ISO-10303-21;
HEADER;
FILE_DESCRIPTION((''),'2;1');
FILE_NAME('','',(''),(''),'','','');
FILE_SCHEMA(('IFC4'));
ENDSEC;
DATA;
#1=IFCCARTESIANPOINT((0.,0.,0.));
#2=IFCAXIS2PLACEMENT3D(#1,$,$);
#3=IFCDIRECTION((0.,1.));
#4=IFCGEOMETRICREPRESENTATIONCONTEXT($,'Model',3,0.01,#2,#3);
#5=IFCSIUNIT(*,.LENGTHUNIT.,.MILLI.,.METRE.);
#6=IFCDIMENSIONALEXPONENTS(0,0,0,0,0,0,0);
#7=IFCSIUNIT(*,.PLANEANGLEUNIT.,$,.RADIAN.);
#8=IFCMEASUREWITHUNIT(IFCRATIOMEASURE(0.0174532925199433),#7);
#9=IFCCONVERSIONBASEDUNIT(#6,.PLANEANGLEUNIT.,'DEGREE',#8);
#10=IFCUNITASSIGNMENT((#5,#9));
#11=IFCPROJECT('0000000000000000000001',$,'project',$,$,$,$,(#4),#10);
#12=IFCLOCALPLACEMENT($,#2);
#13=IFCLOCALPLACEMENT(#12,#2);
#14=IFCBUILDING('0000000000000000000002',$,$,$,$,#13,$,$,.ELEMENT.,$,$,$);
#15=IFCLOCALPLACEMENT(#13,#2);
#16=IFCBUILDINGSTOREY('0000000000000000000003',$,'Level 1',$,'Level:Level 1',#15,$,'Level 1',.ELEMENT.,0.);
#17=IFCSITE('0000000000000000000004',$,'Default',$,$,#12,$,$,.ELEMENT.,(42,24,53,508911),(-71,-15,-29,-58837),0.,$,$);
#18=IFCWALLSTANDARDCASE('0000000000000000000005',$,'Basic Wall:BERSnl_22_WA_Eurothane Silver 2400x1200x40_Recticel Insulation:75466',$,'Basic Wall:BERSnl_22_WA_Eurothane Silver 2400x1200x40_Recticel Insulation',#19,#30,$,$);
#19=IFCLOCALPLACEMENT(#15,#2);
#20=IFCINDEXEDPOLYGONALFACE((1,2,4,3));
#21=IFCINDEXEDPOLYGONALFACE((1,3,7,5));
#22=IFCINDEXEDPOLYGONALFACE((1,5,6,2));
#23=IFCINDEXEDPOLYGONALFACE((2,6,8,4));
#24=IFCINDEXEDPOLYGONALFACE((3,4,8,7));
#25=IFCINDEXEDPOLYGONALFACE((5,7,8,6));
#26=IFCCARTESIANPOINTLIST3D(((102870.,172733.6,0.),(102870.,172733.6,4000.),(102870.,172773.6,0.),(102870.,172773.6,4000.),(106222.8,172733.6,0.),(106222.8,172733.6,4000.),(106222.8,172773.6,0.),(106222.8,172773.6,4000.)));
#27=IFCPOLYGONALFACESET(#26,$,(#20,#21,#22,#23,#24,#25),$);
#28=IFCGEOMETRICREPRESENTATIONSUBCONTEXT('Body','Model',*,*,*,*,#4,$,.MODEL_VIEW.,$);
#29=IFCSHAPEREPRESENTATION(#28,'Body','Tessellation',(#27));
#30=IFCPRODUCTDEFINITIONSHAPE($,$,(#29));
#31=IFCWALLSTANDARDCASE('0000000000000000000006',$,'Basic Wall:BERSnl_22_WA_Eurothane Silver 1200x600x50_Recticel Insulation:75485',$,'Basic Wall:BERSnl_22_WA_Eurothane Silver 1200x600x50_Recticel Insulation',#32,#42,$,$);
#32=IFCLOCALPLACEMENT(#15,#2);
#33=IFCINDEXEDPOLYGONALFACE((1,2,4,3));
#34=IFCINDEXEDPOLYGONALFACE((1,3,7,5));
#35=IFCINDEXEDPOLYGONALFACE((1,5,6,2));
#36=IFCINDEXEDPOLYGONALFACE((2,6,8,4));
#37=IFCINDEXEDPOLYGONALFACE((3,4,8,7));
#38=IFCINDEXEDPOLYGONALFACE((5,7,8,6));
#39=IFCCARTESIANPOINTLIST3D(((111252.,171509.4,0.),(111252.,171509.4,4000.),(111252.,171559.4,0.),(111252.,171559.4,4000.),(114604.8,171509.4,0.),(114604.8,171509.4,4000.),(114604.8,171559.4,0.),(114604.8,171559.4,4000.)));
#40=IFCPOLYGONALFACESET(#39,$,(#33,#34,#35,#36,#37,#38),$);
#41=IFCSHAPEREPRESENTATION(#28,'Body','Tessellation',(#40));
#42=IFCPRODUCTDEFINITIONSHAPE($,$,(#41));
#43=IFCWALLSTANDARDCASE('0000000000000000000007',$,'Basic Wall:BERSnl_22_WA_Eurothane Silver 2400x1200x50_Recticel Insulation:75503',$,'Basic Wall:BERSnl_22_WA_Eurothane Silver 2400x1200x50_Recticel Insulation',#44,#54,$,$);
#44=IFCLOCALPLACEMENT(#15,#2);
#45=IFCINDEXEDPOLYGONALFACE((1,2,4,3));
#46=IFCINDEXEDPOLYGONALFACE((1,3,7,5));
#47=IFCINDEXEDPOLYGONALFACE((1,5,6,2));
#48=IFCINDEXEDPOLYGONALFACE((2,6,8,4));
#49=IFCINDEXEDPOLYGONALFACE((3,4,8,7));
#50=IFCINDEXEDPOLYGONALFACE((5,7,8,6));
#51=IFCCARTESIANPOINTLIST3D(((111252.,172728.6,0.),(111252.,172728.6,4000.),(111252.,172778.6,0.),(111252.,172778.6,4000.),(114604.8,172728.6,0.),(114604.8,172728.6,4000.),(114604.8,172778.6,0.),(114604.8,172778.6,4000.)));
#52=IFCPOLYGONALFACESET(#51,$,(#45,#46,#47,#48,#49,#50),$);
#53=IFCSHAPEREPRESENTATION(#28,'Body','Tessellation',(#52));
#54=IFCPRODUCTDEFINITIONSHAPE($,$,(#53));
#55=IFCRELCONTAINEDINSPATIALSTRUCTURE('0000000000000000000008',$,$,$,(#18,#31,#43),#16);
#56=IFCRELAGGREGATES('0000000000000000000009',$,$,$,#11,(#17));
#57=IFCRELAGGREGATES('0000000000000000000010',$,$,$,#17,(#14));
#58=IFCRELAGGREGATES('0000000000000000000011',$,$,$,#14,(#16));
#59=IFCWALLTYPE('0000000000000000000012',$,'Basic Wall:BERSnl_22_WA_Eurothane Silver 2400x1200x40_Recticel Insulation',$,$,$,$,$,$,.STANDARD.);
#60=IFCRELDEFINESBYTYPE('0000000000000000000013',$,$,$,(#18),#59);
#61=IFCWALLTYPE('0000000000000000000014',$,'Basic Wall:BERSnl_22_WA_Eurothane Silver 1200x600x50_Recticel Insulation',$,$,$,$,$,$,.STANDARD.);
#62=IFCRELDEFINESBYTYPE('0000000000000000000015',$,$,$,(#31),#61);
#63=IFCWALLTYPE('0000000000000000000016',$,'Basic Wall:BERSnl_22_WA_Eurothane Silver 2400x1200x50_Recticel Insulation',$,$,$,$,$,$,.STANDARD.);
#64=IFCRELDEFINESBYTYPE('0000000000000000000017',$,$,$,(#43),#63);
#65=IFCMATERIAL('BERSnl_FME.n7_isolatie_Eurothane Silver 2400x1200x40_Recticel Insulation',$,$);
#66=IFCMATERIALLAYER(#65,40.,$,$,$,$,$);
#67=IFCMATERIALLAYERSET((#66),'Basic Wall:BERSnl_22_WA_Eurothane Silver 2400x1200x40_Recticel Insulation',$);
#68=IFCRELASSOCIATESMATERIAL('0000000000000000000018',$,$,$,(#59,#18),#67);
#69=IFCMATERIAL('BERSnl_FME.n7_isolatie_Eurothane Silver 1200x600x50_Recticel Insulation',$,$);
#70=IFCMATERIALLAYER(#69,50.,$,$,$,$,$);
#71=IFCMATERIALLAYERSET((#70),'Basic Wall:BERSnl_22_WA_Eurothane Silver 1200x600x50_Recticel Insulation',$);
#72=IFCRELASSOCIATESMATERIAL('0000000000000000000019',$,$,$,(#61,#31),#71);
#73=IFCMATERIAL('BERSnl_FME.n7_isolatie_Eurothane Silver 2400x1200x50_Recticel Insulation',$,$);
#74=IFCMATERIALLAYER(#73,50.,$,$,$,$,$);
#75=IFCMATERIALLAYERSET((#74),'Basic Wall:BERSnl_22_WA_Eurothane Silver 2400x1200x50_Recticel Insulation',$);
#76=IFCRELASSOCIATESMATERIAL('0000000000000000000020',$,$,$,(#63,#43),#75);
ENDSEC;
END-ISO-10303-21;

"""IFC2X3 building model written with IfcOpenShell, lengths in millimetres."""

from ifc_helpers import new_model, entity, si_unit, converted_unit, direction, frame, frame_2d, origin, place, context, subcontext, project, spatial, rectangle, extrude, material, layer, layer_set, layer_usage, type_object, element, save


model = new_model("IFC2X3")

# Units and contexts
model_context = context("Model", 3, precision=0.01, world=origin(), true_north=direction((0.0, 1.0)))
body_context = subcontext(model_context, "Body", "Model", "MODEL_VIEW")
ifc_project = project(units=[si_unit("LENGTHUNIT", "METRE", prefix="MILLI"), converted_unit("PLANEANGLEUNIT", "DEGREE", entity("IfcRatioMeasure", 0.0174532925199433), si_unit("PLANEANGLEUNIT", "RADIAN"), dimensions=[0, 0, 0, 0, 0, 0, 0])], contexts=[model_context])

# Site, building, storey
site_placement = place(None, origin())
site = spatial("IfcSite", under=ifc_project, at=site_placement, Name="Default", CompositionType="ELEMENT", RefLatitude=(42, 24, 53, 508911), RefLongitude=(-71, -15, -29, -58837), RefElevation=0.0)
building_placement = place(site_placement, origin())
building = spatial("IfcBuilding", under=site, at=building_placement, CompositionType="ELEMENT")
storey_placement = place(building_placement, origin())
storey = spatial("IfcBuildingStorey", under=building, at=storey_placement, Name="Level 1", ObjectType="Level:Level 1", LongName="Level 1", CompositionType="ELEMENT", Elevation=0.0)

# Shared definitions
ifc_material_1 = material(Name="BERSnl_FME.n7_isolatie_Eurothane Silver 2400x1200x40_Recticel Insulation")
ifc_material_2 = material(Name="BERSnl_FME.n7_isolatie_Eurothane Silver 1200x600x50_Recticel Insulation")
ifc_material_3 = material(Name="BERSnl_FME.n7_isolatie_Eurothane Silver 2400x1200x50_Recticel Insulation")

# Walls
ifc_layer_1 = layer(ifc_material_1, 40.0)
ifc_layer_set_1 = layer_set([ifc_layer_1], Name="Basic Wall:BERSnl_22_WA_Eurothane Silver 2400x1200x40_Recticel Insulation")
ifc_layer_usage_1 = layer_usage(ifc_layer_set_1, "AXIS2", "NEGATIVE", 20.0)
wall_type_1 = type_object("IfcWallType", Name="Basic Wall:BERSnl_22_WA_Eurothane Silver 2400x1200x40_Recticel Insulation", PredefinedType="STANDARD", material=ifc_layer_set_1)
wall_1_placement = place(storey_placement, frame((102870.0, 172753.6, 0.0)))
element("IfcWallStandardCase", 1, at=wall_1_placement, inside=storey, type_object=wall_type_1, material=ifc_layer_usage_1, Name="Basic Wall:BERSnl_22_WA_Eurothane Silver 2400x1200x40_Recticel Insulation:75466", ObjectType="Basic Wall:BERSnl_22_WA_Eurothane Silver 2400x1200x40_Recticel Insulation", context=body_context, shape_type="SweptSolid", body=[
    extrude(rectangle(XDim=3352.8, YDim=40.0, at=frame_2d((1676.4, 0.0), x_axis=(-1.0, 0.0))), origin(), (0.0, 0.0, 1.0), 4000.0),
])
ifc_layer_2 = layer(ifc_material_2, 50.0)
ifc_layer_set_2 = layer_set([ifc_layer_2], Name="Basic Wall:BERSnl_22_WA_Eurothane Silver 1200x600x50_Recticel Insulation")
ifc_layer_usage_2 = layer_usage(ifc_layer_set_2, "AXIS2", "NEGATIVE", 25.0)
wall_type_2 = type_object("IfcWallType", Name="Basic Wall:BERSnl_22_WA_Eurothane Silver 1200x600x50_Recticel Insulation", PredefinedType="STANDARD", material=ifc_layer_set_2)
wall_2_placement = place(storey_placement, frame((111252.0, 171534.4, 0.0)))
element("IfcWallStandardCase", 2, at=wall_2_placement, inside=storey, type_object=wall_type_2, material=ifc_layer_usage_2, Name="Basic Wall:BERSnl_22_WA_Eurothane Silver 1200x600x50_Recticel Insulation:75485", ObjectType="Basic Wall:BERSnl_22_WA_Eurothane Silver 1200x600x50_Recticel Insulation", context=body_context, shape_type="SweptSolid", body=[
    extrude(rectangle(XDim=3352.8, YDim=50.0, at=frame_2d((1676.4, 0.0), x_axis=(-1.0, 0.0))), origin(), (0.0, 0.0, 1.0), 4000.0),
])
ifc_layer_3 = layer(ifc_material_3, 50.0)
ifc_layer_set_3 = layer_set([ifc_layer_3], Name="Basic Wall:BERSnl_22_WA_Eurothane Silver 2400x1200x50_Recticel Insulation")
ifc_layer_usage_3 = layer_usage(ifc_layer_set_3, "AXIS2", "NEGATIVE", 25.0)
wall_type_3 = type_object("IfcWallType", Name="Basic Wall:BERSnl_22_WA_Eurothane Silver 2400x1200x50_Recticel Insulation", PredefinedType="STANDARD", material=ifc_layer_set_3)
wall_3_placement = place(storey_placement, frame((111252.0, 172753.6, 0.0)))
element("IfcWallStandardCase", 3, at=wall_3_placement, inside=storey, type_object=wall_type_3, material=ifc_layer_usage_3, Name="Basic Wall:BERSnl_22_WA_Eurothane Silver 2400x1200x50_Recticel Insulation:75503", ObjectType="Basic Wall:BERSnl_22_WA_Eurothane Silver 2400x1200x50_Recticel Insulation", context=body_context, shape_type="SweptSolid", body=[
    extrude(rectangle(XDim=3352.8, YDim=50.0, at=frame_2d((1676.4, 0.0), x_axis=(-1.0, 0.0))), origin(), (0.0, 0.0, 1.0), 4000.0),
])

save(model, "model.ifc")
